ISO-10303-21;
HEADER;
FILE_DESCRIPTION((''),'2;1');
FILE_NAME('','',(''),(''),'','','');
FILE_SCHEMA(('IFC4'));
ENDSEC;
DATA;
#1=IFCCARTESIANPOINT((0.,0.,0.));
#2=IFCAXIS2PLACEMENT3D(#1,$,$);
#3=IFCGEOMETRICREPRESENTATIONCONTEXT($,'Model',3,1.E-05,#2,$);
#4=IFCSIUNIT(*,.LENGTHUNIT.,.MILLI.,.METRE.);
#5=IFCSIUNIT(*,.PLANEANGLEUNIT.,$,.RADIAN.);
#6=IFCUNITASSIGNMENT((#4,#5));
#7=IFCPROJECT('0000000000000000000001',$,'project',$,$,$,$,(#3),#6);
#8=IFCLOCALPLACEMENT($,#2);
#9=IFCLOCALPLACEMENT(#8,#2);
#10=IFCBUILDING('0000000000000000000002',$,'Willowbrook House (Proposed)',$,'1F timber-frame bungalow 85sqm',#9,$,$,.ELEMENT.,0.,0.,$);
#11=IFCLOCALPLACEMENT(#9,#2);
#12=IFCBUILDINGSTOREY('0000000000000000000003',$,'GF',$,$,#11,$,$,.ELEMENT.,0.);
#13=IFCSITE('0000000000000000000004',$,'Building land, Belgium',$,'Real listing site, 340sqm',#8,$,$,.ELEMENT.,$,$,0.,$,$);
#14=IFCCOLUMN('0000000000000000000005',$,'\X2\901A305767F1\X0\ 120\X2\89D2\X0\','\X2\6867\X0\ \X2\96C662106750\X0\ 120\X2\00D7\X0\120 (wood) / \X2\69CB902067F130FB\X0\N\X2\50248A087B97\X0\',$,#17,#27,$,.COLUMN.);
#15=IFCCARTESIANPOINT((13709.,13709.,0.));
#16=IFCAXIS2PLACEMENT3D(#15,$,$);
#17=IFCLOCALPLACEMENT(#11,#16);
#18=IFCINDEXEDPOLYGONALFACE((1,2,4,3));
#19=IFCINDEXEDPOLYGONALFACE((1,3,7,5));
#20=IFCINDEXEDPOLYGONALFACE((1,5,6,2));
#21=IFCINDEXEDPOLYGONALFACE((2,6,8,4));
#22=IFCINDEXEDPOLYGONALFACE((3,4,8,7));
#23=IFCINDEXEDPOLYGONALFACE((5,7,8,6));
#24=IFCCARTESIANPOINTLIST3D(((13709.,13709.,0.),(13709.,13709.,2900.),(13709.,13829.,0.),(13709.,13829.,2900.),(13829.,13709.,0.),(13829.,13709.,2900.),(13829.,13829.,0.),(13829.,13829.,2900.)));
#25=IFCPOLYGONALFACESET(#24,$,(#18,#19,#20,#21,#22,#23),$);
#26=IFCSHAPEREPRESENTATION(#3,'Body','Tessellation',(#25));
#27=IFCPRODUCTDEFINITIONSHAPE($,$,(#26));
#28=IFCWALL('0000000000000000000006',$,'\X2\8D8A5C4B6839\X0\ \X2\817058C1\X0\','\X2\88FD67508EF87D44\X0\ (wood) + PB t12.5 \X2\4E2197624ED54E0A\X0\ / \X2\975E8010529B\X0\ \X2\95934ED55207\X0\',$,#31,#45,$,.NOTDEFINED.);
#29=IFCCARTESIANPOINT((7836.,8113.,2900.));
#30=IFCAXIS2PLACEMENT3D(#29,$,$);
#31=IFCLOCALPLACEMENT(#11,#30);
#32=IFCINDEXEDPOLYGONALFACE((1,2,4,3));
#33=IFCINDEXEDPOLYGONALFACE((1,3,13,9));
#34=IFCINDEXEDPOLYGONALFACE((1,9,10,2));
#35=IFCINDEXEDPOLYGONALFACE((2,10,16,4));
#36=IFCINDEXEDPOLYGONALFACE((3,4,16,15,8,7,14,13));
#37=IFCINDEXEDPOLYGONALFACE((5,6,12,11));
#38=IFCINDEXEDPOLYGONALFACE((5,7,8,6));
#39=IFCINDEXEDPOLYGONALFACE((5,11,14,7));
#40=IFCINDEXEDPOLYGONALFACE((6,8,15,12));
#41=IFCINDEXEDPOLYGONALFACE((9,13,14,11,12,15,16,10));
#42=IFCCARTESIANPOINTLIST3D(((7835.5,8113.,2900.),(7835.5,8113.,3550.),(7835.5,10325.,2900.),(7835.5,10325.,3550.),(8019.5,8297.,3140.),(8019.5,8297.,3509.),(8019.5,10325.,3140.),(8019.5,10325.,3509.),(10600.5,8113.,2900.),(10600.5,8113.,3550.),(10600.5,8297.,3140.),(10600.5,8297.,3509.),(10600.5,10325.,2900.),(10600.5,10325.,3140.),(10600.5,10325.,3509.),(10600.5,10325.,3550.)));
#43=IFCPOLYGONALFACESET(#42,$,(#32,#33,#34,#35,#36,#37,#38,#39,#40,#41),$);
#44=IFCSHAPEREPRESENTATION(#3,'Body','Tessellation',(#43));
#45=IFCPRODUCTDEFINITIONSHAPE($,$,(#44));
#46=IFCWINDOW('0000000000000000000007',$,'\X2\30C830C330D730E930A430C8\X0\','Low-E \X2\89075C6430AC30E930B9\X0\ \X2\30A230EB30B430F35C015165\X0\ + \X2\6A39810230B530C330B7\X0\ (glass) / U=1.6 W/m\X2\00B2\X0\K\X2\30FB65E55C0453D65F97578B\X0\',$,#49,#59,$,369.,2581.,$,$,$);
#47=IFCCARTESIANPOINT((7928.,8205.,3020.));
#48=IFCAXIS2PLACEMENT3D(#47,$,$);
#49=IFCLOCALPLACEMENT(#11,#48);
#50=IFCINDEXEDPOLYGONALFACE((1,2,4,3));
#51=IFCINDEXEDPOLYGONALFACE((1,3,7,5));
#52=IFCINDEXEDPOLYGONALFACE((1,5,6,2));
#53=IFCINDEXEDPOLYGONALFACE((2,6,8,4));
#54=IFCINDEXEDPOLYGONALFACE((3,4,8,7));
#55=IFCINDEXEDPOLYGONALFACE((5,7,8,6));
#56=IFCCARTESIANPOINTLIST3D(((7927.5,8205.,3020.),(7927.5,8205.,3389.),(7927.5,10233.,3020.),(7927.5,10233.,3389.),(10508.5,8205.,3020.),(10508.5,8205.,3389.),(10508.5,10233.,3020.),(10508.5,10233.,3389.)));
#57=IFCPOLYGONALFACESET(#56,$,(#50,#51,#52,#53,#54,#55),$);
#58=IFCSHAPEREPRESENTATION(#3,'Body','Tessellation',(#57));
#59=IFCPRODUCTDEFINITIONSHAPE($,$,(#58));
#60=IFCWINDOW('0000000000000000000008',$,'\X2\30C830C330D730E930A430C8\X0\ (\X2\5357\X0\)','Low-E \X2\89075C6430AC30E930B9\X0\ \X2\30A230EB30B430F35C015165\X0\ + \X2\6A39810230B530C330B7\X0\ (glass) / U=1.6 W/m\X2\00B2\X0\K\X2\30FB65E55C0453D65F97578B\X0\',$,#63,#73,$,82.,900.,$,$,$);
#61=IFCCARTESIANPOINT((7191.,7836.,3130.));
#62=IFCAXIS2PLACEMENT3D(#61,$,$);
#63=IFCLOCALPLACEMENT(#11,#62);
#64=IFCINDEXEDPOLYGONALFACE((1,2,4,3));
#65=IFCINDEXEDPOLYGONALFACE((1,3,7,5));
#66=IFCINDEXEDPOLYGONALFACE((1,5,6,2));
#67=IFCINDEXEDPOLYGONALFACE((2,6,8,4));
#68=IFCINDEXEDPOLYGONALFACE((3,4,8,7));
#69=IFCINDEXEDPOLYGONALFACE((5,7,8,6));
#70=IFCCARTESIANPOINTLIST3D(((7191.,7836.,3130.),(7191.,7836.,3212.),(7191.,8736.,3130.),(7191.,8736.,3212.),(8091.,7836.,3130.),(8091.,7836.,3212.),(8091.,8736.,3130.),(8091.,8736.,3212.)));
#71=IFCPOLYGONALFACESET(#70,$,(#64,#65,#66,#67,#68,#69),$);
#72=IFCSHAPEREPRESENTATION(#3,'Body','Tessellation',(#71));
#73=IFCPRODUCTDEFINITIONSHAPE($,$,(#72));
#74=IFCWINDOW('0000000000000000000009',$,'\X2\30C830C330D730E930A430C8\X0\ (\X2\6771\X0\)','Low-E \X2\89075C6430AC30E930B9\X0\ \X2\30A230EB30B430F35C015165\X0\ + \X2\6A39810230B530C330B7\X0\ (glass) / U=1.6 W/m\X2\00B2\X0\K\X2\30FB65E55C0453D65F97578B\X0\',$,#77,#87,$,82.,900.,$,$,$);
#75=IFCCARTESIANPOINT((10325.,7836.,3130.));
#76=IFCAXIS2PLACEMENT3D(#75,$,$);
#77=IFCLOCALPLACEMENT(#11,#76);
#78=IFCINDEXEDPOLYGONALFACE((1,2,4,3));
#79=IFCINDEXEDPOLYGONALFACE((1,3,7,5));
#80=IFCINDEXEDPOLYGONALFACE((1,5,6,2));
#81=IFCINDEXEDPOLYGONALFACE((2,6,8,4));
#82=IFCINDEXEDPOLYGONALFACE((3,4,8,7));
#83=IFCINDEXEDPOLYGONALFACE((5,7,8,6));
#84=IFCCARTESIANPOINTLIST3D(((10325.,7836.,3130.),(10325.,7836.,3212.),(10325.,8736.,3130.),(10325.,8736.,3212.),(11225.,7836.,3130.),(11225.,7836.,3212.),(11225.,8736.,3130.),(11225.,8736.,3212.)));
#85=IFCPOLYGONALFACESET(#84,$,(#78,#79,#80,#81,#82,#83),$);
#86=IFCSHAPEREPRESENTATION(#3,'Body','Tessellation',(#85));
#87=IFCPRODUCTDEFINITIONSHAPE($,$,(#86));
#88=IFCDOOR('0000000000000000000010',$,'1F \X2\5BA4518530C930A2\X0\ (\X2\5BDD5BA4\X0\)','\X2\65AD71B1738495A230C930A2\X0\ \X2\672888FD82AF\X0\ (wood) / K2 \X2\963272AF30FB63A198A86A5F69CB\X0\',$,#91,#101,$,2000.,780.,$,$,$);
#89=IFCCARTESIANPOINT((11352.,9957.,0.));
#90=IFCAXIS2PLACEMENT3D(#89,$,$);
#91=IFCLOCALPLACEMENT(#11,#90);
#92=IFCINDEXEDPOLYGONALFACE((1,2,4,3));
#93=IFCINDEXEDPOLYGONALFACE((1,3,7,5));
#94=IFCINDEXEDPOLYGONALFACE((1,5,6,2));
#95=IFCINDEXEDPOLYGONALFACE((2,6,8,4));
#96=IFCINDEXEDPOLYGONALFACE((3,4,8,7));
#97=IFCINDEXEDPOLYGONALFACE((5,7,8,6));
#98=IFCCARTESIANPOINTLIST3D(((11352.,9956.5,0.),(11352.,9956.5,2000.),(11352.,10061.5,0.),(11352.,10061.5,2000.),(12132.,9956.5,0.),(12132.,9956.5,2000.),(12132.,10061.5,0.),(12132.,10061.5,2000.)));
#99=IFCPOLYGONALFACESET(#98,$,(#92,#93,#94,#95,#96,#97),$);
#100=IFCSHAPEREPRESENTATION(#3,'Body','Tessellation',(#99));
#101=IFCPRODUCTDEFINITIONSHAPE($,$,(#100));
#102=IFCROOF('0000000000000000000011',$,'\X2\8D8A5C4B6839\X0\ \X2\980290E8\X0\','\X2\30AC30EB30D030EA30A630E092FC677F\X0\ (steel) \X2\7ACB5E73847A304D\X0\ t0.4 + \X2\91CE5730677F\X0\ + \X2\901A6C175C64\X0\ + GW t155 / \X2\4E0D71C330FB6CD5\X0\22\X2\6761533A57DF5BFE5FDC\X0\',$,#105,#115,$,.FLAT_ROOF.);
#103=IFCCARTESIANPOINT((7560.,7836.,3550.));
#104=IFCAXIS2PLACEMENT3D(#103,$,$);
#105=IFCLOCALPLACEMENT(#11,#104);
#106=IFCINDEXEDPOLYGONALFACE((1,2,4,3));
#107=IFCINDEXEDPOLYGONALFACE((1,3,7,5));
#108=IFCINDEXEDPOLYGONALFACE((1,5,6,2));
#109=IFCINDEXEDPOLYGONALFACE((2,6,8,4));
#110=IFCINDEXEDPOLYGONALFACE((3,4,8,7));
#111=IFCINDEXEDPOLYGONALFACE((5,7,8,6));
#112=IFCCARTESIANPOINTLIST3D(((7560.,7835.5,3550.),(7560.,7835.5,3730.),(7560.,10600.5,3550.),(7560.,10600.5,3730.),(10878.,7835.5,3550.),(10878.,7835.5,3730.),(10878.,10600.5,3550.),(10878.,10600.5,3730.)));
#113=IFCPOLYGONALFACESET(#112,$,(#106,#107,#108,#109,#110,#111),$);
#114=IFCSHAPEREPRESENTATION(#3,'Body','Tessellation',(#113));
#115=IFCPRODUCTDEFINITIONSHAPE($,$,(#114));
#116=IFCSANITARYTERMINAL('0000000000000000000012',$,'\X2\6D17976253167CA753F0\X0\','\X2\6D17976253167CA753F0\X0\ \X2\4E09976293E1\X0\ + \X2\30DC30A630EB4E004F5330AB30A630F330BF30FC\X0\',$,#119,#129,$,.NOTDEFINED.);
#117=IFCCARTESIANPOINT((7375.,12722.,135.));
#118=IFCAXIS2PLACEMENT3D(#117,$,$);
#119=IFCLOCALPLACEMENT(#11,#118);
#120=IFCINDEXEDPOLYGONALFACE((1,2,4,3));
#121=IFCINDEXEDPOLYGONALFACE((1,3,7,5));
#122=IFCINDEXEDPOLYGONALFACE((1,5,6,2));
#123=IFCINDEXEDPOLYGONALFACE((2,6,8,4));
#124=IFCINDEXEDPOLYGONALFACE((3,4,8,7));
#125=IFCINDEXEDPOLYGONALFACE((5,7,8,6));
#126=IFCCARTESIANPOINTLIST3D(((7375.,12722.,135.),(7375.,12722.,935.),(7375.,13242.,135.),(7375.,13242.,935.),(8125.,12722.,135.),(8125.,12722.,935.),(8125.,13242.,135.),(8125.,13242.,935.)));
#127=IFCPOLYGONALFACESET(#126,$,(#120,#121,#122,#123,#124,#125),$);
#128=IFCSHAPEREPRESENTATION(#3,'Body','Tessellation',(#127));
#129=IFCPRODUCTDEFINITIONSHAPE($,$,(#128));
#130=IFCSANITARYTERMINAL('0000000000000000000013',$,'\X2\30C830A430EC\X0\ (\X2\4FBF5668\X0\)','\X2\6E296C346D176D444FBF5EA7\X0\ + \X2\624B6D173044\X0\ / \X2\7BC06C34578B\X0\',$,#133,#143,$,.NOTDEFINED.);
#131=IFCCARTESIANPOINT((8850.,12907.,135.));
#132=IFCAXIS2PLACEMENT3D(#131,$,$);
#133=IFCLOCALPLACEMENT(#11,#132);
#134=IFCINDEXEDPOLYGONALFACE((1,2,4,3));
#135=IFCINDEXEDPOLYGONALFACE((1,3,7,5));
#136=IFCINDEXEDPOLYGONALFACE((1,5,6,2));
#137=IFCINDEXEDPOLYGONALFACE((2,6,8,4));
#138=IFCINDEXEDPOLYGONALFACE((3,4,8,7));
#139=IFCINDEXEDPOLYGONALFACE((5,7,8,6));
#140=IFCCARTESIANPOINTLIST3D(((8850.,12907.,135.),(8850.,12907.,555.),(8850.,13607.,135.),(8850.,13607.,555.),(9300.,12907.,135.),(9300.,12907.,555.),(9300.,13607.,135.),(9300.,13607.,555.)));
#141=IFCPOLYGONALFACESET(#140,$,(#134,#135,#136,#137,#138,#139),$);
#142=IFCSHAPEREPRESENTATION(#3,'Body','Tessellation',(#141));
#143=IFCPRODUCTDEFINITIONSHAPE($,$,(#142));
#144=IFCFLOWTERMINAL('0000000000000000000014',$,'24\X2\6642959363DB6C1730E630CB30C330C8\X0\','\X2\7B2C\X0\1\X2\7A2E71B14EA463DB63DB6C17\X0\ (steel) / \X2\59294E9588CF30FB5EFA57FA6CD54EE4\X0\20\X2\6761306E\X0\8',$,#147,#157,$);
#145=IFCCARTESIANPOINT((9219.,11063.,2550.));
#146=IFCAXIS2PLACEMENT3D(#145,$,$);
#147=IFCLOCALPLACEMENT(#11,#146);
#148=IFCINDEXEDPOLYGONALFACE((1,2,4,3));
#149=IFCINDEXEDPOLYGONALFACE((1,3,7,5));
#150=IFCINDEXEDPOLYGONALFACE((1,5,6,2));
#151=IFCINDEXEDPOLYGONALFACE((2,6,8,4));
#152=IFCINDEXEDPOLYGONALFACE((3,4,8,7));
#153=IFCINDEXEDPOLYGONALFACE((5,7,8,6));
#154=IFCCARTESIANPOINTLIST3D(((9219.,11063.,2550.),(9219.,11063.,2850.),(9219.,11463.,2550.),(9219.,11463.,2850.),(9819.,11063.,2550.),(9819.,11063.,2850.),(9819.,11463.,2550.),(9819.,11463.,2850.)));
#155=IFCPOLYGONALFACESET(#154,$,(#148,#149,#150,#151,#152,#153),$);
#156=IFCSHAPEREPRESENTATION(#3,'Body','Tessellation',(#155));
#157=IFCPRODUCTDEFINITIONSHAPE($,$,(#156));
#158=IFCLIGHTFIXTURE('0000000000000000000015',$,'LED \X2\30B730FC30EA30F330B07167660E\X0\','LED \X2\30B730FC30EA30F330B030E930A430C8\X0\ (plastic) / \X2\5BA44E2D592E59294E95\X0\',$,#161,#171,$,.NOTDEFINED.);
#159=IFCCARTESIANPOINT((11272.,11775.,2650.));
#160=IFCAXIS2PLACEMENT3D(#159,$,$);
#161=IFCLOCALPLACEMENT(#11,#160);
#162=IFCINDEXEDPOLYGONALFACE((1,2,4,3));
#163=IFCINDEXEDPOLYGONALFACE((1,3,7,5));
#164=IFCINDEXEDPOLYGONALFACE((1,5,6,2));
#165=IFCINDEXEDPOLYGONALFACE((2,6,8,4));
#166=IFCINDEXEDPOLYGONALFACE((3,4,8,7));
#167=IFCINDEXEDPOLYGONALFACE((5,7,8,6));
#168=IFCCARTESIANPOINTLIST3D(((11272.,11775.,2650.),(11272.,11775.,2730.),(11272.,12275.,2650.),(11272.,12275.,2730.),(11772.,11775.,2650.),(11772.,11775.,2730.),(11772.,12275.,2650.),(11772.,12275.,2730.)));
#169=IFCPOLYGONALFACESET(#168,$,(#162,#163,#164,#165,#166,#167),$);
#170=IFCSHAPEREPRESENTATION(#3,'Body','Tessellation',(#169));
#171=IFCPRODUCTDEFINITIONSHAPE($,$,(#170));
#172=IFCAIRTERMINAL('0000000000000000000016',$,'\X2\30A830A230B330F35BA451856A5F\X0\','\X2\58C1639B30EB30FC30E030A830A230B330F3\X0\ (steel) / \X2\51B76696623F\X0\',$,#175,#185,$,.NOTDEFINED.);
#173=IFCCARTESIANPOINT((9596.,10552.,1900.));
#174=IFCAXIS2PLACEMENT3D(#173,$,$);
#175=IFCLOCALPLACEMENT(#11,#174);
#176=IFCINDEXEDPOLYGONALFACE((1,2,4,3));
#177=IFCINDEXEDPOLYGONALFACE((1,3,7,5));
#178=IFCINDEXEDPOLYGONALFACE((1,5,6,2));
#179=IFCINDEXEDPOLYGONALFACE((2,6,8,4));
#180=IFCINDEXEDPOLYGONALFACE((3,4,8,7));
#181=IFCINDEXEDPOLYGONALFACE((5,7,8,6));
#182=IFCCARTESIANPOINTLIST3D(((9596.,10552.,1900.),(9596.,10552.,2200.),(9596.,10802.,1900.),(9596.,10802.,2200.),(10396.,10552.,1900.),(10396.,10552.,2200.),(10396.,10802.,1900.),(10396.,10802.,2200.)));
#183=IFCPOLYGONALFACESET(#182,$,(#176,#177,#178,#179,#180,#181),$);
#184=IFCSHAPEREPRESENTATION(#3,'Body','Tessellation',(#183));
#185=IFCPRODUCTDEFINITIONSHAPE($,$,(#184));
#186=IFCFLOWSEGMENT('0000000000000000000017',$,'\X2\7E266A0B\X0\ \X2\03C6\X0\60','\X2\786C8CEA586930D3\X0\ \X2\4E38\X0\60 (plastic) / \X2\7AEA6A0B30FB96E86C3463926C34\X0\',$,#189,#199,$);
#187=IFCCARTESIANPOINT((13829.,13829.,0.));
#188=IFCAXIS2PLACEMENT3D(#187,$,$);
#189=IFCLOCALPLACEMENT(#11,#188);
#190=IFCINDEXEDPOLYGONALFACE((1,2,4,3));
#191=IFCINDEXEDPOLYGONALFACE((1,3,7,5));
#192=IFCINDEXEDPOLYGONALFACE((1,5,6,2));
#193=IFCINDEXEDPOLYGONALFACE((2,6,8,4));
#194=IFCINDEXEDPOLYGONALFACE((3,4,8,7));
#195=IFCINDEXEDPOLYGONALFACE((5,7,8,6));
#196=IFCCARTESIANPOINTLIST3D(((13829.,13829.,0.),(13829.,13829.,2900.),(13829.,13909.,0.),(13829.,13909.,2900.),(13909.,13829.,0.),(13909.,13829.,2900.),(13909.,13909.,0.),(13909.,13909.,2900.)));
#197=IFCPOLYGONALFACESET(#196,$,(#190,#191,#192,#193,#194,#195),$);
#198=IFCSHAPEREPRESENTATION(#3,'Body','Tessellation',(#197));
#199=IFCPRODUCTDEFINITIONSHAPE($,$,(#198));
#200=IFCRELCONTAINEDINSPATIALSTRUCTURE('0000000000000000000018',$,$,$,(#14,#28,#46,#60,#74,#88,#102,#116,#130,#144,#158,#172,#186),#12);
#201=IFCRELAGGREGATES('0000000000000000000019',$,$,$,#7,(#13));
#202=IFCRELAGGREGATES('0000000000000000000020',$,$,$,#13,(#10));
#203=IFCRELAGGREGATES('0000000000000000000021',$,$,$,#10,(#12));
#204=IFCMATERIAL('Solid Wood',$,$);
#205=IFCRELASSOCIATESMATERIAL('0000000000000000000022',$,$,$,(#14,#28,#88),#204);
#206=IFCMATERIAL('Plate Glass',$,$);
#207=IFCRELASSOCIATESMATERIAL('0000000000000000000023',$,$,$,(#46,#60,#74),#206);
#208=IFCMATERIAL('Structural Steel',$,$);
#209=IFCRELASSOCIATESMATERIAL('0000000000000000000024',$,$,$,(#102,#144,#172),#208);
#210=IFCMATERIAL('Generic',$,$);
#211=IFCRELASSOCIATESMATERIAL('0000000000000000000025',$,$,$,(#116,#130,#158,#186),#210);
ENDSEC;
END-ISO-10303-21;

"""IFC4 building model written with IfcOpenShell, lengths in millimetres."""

from ifc_helpers import new_model, si_unit, frame, frame_2d, origin, place, context, project, spatial, rectangle, extrude, material, element, fill, save


model = new_model("IFC4")

# Units and contexts
model_context = context("Model", 3, precision=1e-05, world=origin())
ifc_project = project(units=[si_unit("LENGTHUNIT", "METRE", prefix="MILLI"), si_unit("PLANEANGLEUNIT", "RADIAN")], contexts=[model_context])

# Site, building, storey
site_placement = place(None, origin())
site = spatial("IfcSite", under=ifc_project, at=site_placement, Name="Building land, Belgium", ObjectType="Real listing site, 340sqm", CompositionType="ELEMENT", RefElevation=0.0)
building_placement = place(site_placement, origin())
building = spatial("IfcBuilding", under=site, at=building_placement, Name="Willowbrook House (Proposed)", ObjectType="1F timber-frame bungalow 85sqm", CompositionType="ELEMENT", ElevationOfRefHeight=0.0, ElevationOfTerrain=0.0)
storey_placement = place(building_placement, origin())
storey = spatial("IfcBuildingStorey", under=building, at=storey_placement, Name="GF", CompositionType="ELEMENT", Elevation=0.0)

# Column
ifc_material_1 = material(Name="Solid Wood")
column_1_placement = place(storey_placement, frame((13709.0, 13709.0, 0.0)))
element("IfcColumn", 1, at=column_1_placement, inside=storey, material=ifc_material_1, Name="通し柱 120角", Description="桧 集成材 120×120 (wood) / 構造柱・N値計算", PredefinedType="COLUMN", context=model_context, shape_type="SweptSolid", body=[
    extrude(rectangle(XDim=120.0, YDim=120.0, at=frame_2d((60.0, 60.0))), frame((13709.0, 13709.0, 0.0)), (0.0, 0.0, 1.0), 2900.0),
])

# Wall, openings, windows
wall_1_placement = place(storey_placement, frame((7836.0, 8113.0, 2900.0)))
wall_1 = element("IfcWall", 2, at=wall_1_placement, inside=storey, material=ifc_material_1, Name="越屋根 腰壁", Description="製材軸組 (wood) + PB t12.5 両面仕上 / 非耐力 間仕切", PredefinedType="NOTDEFINED", context=model_context, shape_type="SweptSolid", body=[
    extrude(rectangle(XDim=2765.0, YDim=2212.0, at=frame_2d((1382.0, 1106.0))), frame((7836.0, 8113.0, 2900.0)), (0.0, 0.0, 1.0), 650.0),
])
opening_1_placement = place(storey_placement, frame((7928.0, 8205.0, 3020.0)))
opening_1 = element("IfcOpeningElement", 3, at=opening_1_placement, cuts=wall_1, PredefinedType="NOTDEFINED", context=model_context, shape_type="SweptSolid", body=[
    extrude(rectangle(XDim=2581.0, YDim=2028.0, at=frame_2d((1290.0, 1014.0))), frame((7928.0, 8205.0, 3020.0)), (0.0, 0.0, 1.0), 369.0),
])
opening_2_placement = place(storey_placement, frame((7191.0, 7836.0, 3130.0)))
opening_2 = element("IfcOpeningElement", 4, at=opening_2_placement, cuts=wall_1, PredefinedType="NOTDEFINED", context=model_context, shape_type="SweptSolid", body=[
    extrude(rectangle(XDim=900.0, YDim=900.0, at=frame_2d((450.0, 450.0))), frame((7191.0, 7836.0, 3130.0)), (0.0, 0.0, 1.0), 82.0),
])
opening_3_placement = place(storey_placement, frame((10325.0, 7836.0, 3130.0)))
opening_3 = element("IfcOpeningElement", 5, at=opening_3_placement, cuts=wall_1, PredefinedType="NOTDEFINED", context=model_context, shape_type="SweptSolid", body=[
    extrude(rectangle(XDim=900.0, YDim=900.0, at=frame_2d((450.0, 450.0))), frame((10325.0, 7836.0, 3130.0)), (0.0, 0.0, 1.0), 82.0),
])
ifc_material_2 = material(Name="Plate Glass")
window_1_placement = place(storey_placement, frame((7928.0, 8205.0, 3020.0)))
window_1 = element("IfcWindow", 6, at=window_1_placement, inside=storey, material=ifc_material_2, Name="トップライト", Description="Low-E 複層ガラス アルゴン封入 + 樹脂サッシ (glass) / U=1.6 W/m²K・日射取得型", OverallHeight=369.0, OverallWidth=2581.0, context=model_context, shape_type="SweptSolid", body=[
    extrude(rectangle(XDim=2581.0, YDim=2028.0, at=frame_2d((1290.0, 1014.0))), frame((7928.0, 8205.0, 3020.0)), (0.0, 0.0, 1.0), 369.0),
])
fill(opening_1, window_1)
window_2_placement = place(storey_placement, frame((7191.0, 7836.0, 3130.0)))
window_2 = element("IfcWindow", 7, at=window_2_placement, inside=storey, material=ifc_material_2, Name="トップライト (南)", Description="Low-E 複層ガラス アルゴン封入 + 樹脂サッシ (glass) / U=1.6 W/m²K・日射取得型", OverallHeight=82.0, OverallWidth=900.0, context=model_context, shape_type="SweptSolid", body=[
    extrude(rectangle(XDim=900.0, YDim=900.0, at=frame_2d((450.0, 450.0))), frame((7191.0, 7836.0, 3130.0)), (0.0, 0.0, 1.0), 82.0),
])
fill(opening_2, window_2)
window_3_placement = place(storey_placement, frame((10325.0, 7836.0, 3130.0)))
window_3 = element("IfcWindow", 8, at=window_3_placement, inside=storey, material=ifc_material_2, Name="トップライト (東)", Description="Low-E 複層ガラス アルゴン封入 + 樹脂サッシ (glass) / U=1.6 W/m²K・日射取得型", OverallHeight=82.0, OverallWidth=900.0, context=model_context, shape_type="SweptSolid", body=[
    extrude(rectangle(XDim=900.0, YDim=900.0, at=frame_2d((450.0, 450.0))), frame((10325.0, 7836.0, 3130.0)), (0.0, 0.0, 1.0), 82.0),
])
fill(opening_3, window_3)

# Door
door_placement = place(storey_placement, frame((11352.0, 9957.0, 0.0)))
element("IfcDoor", 9, at=door_placement, inside=storey, material=ifc_material_1, Name="1F 室内ドア (寝室)", Description="断熱玄関ドア 木製芯 (wood) / K2 防犯・採風機構", OverallHeight=2000.0, OverallWidth=780.0, context=model_context, shape_type="SweptSolid", body=[
    extrude(rectangle(XDim=780.0, YDim=105.0, at=frame_2d((390.0, 52.0))), frame((11352.0, 9957.0, 0.0)), (0.0, 0.0, 1.0), 2000.0),
])

# Roof
ifc_material_3 = material(Name="Structural Steel")
roof_placement = place(storey_placement, frame((7560.0, 7836.0, 3550.0)))
element("IfcRoof", 10, at=roof_placement, inside=storey, material=ifc_material_3, Name="越屋根 頂部", Description="ガルバリウム鋼板 (steel) 立平葺き t0.4 + 野地板 + 通気層 + GW t155 / 不燃・法22条区域対応", PredefinedType="FLAT_ROOF", context=model_context, shape_type="SweptSolid", body=[
    extrude(rectangle(XDim=3318.0, YDim=2765.0, at=frame_2d((1659.0, 1382.0))), frame((7560.0, 7836.0, 3550.0)), (0.0, 0.0, 1.0), 180.0),
])

# Sanitary terminals
ifc_material_4 = material(Name="Generic")
sanitary_terminal_1_placement = place(storey_placement, frame((7375.0, 12722.0, 135.0)))
element("IfcSanitaryTerminal", 11, at=sanitary_terminal_1_placement, inside=storey, material=ifc_material_4, Name="洗面化粧台", Description="洗面化粧台 三面鏡 + ボウル一体カウンター", PredefinedType="NOTDEFINED", context=model_context, shape_type="SweptSolid", body=[
    extrude(rectangle(XDim=750.0, YDim=520.0, at=frame_2d((375.0, 260.0))), frame((7375.0, 12722.0, 135.0)), (0.0, 0.0, 1.0), 800.0),
])
sanitary_terminal_2_placement = place(storey_placement, frame((8850.0, 12907.0, 135.0)))
element("IfcSanitaryTerminal", 12, at=sanitary_terminal_2_placement, inside=storey, material=ifc_material_4, Name="トイレ (便器)", Description="温水洗浄便座 + 手洗い / 節水型", PredefinedType="NOTDEFINED", context=model_context, shape_type="SweptSolid", body=[
    extrude(rectangle(XDim=450.0, YDim=700.0, at=frame_2d((225.0, 350.0))), frame((8850.0, 12907.0, 135.0)), (0.0, 0.0, 1.0), 420.0),
])

# Flow terminal
flow_terminal_placement = place(storey_placement, frame((9219.0, 11063.0, 2550.0)))
element("IfcFlowTerminal", 13, at=flow_terminal_placement, inside=storey, material=ifc_material_3, Name="24時間換気ユニット", Description="第1種熱交換換気 (steel) / 天井裏・建基法令20条の8", context=model_context, shape_type="SweptSolid", body=[
    extrude(rectangle(XDim=600.0, YDim=400.0, at=frame_2d((300.0, 200.0))), frame((9219.0, 11063.0, 2550.0)), (0.0, 0.0, 1.0), 300.0),
])

# Light fixture
light_fixture_placement = place(storey_placement, frame((11272.0, 11775.0, 2650.0)))
element("IfcLightFixture", 14, at=light_fixture_placement, inside=storey, material=ifc_material_4, Name="LED シーリング照明", Description="LED シーリングライト (plastic) / 室中央天井", PredefinedType="NOTDEFINED", context=model_context, shape_type="SweptSolid", body=[
    extrude(rectangle(XDim=500.0, YDim=500.0, at=frame_2d((250.0, 250.0))), frame((11272.0, 11775.0, 2650.0)), (0.0, 0.0, 1.0), 80.0),
])

# Air terminal
air_terminal_placement = place(storey_placement, frame((9596.0, 10552.0, 1900.0)))
element("IfcAirTerminal", 15, at=air_terminal_placement, inside=storey, material=ifc_material_3, Name="エアコン室内機", Description="壁掛ルームエアコン (steel) / 冷暖房", PredefinedType="NOTDEFINED", context=model_context, shape_type="SweptSolid", body=[
    extrude(rectangle(XDim=800.0, YDim=250.0, at=frame_2d((400.0, 125.0))), frame((9596.0, 10552.0, 1900.0)), (0.0, 0.0, 1.0), 300.0),
])

# Flow segment
flow_segment_placement = place(storey_placement, frame((13829.0, 13829.0, 0.0)))
element("IfcFlowSegment", 16, at=flow_segment_placement, inside=storey, material=ifc_material_4, Name="縦樋 φ60", Description="硬質塩ビ 丸60 (plastic) / 竪樋・雨水排水", context=model_context, shape_type="SweptSolid", body=[
    extrude(rectangle(XDim=80.0, YDim=80.0, at=frame_2d((40.0, 40.0))), frame((13829.0, 13829.0, 0.0)), (0.0, 0.0, 1.0), 2900.0),
])

save(model, "model.ifc")
